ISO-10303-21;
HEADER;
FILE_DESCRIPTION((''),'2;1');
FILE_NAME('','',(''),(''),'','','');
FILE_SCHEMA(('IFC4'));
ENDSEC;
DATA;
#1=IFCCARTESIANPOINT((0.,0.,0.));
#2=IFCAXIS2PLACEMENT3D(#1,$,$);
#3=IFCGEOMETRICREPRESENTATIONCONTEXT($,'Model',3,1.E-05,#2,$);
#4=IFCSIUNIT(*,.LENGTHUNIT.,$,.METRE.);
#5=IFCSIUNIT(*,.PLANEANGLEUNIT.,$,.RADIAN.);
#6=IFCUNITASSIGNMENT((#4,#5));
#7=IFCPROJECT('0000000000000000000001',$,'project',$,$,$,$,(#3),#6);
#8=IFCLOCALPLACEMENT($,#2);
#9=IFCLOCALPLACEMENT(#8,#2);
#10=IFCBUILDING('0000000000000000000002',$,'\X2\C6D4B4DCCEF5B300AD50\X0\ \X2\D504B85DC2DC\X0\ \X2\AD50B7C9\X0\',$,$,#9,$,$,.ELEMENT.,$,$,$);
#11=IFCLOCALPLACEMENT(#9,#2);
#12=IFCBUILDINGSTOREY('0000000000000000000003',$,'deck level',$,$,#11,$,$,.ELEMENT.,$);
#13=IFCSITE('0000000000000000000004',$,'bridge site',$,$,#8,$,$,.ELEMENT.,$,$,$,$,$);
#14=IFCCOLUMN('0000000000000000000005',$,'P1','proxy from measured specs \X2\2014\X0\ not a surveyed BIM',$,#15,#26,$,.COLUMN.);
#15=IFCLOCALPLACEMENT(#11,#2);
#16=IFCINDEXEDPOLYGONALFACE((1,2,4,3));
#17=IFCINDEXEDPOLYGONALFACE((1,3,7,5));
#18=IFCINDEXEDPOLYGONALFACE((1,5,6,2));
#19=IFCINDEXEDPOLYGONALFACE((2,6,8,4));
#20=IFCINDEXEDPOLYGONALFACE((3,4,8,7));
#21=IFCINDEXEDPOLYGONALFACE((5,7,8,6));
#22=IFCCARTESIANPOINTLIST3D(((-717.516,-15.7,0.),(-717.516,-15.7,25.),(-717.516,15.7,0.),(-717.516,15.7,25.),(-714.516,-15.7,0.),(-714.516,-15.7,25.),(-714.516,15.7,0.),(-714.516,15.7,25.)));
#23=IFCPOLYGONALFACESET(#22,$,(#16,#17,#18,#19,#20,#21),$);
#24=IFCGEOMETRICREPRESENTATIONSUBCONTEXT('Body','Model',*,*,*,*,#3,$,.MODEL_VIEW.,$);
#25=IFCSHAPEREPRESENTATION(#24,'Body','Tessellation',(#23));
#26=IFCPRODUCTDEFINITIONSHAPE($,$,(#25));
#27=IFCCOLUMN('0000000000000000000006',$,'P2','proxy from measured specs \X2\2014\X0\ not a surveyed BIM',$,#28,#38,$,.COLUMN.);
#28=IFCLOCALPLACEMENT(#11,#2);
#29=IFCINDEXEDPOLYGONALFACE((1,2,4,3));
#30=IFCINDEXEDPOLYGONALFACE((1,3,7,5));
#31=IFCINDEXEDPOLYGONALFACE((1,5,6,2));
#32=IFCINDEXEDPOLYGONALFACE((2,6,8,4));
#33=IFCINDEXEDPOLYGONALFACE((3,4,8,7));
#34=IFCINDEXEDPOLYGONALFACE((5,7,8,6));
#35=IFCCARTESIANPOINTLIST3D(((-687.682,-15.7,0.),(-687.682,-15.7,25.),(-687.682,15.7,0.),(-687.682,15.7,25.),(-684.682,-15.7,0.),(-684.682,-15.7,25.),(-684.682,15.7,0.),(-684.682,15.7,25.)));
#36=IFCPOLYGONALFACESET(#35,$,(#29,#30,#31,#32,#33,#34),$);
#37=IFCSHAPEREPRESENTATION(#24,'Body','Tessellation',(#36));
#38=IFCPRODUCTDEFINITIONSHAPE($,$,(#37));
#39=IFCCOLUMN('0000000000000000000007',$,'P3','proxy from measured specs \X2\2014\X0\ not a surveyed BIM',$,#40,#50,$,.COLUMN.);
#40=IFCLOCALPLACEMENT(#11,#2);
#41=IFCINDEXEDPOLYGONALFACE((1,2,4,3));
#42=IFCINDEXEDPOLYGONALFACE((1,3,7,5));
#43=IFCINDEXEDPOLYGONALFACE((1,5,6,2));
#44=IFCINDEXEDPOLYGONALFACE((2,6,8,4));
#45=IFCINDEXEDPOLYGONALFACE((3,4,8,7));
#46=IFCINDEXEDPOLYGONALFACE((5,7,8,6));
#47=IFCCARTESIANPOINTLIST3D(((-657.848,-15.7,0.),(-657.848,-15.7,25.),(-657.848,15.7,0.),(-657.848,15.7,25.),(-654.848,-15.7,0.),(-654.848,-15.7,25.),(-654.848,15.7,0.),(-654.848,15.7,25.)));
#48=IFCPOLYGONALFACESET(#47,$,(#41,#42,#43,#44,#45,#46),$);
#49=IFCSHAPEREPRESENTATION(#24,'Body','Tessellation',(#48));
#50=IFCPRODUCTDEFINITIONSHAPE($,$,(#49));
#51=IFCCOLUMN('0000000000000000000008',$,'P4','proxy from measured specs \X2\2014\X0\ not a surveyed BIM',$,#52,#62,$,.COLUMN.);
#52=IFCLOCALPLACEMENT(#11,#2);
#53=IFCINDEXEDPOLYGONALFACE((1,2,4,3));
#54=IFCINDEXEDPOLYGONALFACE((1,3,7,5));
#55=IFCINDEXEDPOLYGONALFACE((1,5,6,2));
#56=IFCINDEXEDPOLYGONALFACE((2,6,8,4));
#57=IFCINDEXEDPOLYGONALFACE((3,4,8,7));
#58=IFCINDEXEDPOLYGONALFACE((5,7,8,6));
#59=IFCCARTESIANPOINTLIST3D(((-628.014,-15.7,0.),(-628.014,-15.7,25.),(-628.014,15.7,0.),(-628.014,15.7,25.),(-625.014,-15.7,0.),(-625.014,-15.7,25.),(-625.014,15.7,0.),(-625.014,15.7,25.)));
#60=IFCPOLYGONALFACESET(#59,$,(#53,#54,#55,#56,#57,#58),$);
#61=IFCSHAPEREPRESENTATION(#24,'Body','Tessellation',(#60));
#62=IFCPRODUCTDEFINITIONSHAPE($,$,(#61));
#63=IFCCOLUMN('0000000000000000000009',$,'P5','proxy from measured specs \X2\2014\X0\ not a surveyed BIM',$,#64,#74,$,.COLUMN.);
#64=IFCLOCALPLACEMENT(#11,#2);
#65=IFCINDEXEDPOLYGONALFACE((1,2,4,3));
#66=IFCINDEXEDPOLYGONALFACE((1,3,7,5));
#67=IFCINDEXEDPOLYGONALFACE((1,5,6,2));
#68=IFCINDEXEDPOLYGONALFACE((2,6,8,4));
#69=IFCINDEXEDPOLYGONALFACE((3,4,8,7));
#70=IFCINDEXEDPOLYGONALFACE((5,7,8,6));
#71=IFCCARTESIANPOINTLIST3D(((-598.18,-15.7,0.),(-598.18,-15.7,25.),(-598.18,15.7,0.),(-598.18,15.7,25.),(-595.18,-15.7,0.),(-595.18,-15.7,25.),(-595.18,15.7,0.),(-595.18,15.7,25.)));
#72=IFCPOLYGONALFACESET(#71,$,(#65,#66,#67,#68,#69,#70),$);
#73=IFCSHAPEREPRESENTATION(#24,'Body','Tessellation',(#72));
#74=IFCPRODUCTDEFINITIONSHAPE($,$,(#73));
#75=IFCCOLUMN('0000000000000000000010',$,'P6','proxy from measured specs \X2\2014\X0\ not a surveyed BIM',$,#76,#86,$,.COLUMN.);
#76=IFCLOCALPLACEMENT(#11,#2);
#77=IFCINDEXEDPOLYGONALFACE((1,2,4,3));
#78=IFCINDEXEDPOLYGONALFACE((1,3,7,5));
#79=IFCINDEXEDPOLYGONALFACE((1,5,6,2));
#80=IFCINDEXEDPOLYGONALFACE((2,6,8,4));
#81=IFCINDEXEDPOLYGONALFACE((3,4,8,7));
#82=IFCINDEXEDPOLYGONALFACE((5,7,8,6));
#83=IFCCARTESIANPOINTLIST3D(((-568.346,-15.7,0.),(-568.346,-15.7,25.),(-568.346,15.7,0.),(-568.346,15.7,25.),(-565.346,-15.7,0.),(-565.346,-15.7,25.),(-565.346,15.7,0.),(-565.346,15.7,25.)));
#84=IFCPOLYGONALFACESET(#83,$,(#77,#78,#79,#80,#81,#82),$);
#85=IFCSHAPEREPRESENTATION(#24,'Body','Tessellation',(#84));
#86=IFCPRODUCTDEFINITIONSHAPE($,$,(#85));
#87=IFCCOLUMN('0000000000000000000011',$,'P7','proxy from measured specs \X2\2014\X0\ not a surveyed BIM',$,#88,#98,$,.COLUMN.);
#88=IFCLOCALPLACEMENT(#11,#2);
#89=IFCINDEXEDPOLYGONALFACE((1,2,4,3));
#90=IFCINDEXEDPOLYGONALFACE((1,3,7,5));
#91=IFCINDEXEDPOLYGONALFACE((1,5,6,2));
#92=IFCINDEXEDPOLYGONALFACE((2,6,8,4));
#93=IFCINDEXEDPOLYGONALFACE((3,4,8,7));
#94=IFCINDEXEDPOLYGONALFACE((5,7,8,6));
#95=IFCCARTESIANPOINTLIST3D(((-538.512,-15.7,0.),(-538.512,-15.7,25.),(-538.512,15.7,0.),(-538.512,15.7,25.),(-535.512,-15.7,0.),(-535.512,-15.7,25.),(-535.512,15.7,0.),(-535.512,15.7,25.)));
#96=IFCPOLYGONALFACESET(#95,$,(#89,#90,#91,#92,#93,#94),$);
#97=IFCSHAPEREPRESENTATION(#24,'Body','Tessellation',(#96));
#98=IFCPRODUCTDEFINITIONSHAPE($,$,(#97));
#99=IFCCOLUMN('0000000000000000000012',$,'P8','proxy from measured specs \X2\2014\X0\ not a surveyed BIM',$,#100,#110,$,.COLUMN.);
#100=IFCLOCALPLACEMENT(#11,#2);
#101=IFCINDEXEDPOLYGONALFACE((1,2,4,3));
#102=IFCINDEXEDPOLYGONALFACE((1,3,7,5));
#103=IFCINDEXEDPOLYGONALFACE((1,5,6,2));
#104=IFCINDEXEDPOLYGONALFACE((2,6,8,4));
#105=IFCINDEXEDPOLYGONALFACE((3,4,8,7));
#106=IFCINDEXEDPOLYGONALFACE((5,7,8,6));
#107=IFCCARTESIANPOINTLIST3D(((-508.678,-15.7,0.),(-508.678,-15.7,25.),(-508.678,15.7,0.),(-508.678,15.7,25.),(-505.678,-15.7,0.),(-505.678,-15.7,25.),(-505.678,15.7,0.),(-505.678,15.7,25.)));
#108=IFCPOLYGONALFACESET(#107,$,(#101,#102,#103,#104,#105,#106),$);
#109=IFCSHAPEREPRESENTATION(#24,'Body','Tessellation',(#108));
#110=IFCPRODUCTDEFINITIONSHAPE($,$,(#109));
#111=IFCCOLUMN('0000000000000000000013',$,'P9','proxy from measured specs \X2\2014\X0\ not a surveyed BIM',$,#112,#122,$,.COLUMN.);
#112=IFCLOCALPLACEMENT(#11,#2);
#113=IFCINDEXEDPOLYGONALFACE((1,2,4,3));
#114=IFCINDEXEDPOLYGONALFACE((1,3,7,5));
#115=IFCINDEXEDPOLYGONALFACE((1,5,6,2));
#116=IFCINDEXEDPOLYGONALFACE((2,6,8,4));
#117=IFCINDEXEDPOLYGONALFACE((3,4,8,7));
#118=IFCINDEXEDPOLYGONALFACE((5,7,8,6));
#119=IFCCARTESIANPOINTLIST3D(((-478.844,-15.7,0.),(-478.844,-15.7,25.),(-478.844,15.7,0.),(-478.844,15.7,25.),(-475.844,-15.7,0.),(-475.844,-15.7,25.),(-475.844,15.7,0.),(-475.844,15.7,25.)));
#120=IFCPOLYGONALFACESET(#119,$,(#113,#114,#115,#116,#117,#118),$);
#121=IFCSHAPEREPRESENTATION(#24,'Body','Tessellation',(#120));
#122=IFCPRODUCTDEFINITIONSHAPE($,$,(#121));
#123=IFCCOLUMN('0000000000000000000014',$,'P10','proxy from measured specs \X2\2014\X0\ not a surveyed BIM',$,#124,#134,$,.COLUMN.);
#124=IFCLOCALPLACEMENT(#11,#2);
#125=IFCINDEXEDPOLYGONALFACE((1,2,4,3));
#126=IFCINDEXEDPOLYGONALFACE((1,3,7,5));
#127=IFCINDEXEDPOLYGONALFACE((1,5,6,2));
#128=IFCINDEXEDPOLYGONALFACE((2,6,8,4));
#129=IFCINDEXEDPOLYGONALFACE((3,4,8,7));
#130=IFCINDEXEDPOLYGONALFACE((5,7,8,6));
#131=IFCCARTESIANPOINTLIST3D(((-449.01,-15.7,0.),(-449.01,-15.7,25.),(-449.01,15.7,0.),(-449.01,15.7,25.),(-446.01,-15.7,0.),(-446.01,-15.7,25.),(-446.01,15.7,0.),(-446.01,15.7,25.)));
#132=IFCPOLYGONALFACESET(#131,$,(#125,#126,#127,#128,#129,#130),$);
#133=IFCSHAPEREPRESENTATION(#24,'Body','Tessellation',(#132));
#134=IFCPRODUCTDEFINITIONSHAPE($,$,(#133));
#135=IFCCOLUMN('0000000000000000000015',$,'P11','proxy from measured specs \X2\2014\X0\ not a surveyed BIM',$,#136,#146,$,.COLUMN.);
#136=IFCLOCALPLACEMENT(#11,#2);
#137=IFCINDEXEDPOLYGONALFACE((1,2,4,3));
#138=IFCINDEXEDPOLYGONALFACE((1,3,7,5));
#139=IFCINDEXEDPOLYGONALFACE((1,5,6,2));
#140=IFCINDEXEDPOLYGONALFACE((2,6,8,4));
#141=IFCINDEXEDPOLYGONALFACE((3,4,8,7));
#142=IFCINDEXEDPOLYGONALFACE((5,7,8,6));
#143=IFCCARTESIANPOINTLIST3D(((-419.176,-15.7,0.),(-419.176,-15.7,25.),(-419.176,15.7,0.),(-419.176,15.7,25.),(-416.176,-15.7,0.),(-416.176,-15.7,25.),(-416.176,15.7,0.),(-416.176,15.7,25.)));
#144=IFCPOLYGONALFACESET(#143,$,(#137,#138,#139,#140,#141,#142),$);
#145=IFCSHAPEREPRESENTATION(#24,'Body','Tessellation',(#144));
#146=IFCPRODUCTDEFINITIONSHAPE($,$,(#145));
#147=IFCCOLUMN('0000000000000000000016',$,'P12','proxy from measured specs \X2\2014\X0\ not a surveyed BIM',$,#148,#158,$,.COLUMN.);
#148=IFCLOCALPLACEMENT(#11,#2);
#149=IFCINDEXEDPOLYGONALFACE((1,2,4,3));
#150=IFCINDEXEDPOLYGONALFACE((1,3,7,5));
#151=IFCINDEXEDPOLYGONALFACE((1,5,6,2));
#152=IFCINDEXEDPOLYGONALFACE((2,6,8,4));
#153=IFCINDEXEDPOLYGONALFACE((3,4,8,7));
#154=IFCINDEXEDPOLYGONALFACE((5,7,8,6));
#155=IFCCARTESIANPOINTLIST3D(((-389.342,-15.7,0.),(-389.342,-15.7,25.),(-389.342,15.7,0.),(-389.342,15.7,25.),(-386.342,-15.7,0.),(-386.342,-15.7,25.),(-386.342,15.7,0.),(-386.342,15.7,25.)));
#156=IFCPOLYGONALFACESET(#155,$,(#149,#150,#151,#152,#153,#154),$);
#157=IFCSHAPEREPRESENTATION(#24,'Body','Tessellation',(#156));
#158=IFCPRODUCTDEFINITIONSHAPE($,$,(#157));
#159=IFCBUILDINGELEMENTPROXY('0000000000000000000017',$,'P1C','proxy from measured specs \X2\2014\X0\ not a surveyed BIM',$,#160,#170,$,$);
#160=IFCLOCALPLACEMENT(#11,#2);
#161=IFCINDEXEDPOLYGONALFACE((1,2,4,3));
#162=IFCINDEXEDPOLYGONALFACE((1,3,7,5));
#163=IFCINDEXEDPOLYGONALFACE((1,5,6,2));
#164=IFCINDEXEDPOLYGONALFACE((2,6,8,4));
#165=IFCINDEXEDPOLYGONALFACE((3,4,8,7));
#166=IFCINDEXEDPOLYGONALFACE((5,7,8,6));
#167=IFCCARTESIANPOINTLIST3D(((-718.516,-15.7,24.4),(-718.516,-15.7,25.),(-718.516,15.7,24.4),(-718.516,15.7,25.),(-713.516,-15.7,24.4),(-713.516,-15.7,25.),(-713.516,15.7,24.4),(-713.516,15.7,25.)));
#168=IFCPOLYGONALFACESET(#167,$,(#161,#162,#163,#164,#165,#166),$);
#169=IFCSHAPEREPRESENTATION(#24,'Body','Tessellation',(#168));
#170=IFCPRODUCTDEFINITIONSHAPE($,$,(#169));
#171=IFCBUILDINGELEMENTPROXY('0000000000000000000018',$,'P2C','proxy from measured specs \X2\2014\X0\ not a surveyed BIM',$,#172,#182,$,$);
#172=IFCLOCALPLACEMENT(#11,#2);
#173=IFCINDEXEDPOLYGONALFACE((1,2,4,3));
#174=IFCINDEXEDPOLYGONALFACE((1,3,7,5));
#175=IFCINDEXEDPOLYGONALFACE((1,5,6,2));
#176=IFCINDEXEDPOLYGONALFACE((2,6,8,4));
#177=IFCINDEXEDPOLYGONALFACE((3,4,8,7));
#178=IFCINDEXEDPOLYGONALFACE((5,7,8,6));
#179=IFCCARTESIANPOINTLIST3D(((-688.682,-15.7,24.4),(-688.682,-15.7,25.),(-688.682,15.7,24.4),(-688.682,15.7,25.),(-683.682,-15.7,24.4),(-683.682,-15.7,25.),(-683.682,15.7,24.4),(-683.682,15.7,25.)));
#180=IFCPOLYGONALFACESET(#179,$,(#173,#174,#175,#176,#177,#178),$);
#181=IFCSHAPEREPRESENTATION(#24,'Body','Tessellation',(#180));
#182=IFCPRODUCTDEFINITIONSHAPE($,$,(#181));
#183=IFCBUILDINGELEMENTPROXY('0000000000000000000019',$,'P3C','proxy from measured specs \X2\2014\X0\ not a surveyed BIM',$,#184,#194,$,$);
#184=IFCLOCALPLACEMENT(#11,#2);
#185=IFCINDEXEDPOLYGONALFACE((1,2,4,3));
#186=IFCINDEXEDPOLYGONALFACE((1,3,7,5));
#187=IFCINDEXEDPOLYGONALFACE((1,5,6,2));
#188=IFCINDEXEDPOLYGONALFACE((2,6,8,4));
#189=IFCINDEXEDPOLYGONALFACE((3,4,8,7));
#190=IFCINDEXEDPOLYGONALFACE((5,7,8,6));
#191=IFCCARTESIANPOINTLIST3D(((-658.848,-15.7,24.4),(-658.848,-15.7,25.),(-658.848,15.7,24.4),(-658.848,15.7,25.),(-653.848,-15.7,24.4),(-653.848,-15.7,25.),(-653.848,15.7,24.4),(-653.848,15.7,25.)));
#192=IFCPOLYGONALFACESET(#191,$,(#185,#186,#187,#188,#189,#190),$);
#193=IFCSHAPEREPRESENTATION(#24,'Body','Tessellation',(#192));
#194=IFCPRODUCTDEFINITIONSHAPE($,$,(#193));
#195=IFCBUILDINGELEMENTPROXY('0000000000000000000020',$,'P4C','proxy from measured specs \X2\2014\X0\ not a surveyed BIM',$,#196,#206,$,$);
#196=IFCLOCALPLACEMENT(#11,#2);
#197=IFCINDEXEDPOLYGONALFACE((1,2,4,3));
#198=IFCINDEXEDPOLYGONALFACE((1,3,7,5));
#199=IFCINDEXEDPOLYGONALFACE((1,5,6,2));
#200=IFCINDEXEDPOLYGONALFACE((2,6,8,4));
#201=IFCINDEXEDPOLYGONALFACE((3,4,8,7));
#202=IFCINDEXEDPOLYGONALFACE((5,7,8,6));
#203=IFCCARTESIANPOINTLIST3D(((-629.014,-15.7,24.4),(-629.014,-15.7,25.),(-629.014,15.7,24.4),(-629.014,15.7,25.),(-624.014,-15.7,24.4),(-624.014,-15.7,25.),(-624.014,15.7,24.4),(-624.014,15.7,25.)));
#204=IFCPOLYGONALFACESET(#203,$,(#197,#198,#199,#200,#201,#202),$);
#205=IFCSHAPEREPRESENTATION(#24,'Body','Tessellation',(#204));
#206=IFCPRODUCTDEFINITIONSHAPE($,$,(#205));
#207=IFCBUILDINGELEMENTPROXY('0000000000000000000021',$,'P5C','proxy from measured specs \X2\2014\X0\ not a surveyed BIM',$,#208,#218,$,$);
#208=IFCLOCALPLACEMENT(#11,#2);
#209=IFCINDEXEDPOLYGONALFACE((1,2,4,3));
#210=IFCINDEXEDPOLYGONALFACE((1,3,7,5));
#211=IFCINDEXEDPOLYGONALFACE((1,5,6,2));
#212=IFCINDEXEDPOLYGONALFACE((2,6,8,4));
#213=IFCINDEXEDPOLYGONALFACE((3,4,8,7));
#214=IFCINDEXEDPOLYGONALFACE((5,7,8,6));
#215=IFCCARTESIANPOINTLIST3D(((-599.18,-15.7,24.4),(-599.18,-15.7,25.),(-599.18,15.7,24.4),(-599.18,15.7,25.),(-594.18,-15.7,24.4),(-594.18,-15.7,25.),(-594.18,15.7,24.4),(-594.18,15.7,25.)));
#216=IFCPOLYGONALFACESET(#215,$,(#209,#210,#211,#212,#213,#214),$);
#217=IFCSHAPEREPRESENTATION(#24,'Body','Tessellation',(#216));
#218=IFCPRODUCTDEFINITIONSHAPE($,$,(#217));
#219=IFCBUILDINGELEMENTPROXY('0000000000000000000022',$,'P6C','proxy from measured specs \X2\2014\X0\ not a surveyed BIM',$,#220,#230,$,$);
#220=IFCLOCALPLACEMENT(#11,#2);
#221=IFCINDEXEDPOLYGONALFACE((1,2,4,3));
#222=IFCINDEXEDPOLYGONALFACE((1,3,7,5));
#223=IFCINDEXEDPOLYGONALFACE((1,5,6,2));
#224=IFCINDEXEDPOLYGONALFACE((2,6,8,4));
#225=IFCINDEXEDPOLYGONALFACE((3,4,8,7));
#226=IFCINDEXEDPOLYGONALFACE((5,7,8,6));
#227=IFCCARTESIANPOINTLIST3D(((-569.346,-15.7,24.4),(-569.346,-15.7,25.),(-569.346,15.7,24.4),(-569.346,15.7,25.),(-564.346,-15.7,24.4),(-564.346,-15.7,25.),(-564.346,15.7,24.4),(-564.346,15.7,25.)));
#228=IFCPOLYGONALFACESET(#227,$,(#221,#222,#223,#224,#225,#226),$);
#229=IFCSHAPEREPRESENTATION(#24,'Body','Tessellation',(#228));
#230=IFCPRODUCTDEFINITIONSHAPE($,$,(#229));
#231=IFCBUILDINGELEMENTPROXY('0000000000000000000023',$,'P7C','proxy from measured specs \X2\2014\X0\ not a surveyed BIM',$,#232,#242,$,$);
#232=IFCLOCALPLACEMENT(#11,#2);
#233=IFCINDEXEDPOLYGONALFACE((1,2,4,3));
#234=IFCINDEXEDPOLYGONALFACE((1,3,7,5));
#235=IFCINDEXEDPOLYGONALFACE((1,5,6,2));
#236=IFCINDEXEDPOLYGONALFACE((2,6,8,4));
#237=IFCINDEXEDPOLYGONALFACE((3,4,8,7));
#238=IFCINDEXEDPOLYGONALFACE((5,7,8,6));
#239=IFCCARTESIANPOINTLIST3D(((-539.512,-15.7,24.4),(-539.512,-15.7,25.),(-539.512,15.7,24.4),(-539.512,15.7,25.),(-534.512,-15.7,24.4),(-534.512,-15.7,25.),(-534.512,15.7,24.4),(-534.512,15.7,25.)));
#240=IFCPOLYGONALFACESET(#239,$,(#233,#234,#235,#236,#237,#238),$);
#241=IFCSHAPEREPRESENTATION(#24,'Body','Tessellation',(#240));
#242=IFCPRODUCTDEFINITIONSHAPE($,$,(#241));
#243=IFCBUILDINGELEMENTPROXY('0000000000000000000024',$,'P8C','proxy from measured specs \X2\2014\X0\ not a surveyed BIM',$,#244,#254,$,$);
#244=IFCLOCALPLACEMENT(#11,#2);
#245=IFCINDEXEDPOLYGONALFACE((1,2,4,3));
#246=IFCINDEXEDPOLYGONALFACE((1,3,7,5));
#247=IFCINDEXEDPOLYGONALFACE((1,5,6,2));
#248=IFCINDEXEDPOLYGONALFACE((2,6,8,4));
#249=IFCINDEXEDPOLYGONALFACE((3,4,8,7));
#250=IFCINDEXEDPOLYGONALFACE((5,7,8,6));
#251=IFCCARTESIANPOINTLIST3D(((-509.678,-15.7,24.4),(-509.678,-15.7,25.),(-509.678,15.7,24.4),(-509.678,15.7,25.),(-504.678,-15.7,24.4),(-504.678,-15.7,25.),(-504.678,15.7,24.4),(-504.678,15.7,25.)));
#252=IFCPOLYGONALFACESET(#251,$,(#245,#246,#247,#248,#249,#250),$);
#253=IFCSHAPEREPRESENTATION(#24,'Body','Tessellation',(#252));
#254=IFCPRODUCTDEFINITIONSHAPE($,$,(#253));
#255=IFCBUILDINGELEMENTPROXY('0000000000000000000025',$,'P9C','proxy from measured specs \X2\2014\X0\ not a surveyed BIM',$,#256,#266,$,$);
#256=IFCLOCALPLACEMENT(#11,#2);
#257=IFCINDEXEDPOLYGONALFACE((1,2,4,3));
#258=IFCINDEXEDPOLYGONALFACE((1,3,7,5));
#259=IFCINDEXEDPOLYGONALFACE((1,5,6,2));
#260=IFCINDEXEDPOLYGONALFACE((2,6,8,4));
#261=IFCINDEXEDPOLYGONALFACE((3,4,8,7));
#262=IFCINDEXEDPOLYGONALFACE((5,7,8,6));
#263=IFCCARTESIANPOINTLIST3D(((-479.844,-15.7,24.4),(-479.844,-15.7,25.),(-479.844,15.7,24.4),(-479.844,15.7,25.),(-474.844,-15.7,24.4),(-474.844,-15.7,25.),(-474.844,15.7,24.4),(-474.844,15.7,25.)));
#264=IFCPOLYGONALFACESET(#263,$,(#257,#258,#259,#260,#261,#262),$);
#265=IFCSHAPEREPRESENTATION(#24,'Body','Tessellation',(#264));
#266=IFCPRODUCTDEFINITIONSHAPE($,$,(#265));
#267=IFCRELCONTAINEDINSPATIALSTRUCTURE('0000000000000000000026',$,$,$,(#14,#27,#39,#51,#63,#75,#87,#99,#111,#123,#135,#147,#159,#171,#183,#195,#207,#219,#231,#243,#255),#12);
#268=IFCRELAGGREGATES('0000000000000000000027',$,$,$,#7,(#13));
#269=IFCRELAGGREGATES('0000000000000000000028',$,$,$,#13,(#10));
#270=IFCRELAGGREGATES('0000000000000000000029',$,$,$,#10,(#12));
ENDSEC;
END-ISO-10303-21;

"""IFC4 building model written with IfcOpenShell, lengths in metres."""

from ifc_helpers import new_model, si_unit, frame, origin, origin_2d, place, context, subcontext, project, spatial, rectangle, extrude, element, save


model = new_model("IFC4")

# Units and contexts
model_context = context("Model", 3, precision=1e-05, world=origin())
body_context = subcontext(model_context, "Body", "Model", "MODEL_VIEW")
ifc_project = project(units=[si_unit("LENGTHUNIT", "METRE"), si_unit("PLANEANGLEUNIT", "RADIAN")], contexts=[model_context])

# Site, building, storey
site_placement = place(None, origin())
site = spatial("IfcSite", under=ifc_project, at=site_placement, Name="bridge site", CompositionType="ELEMENT")
building_placement = place(site_placement, origin())
building = spatial("IfcBuilding", under=site, at=building_placement, Name="월드컵대교 프록시 교량", CompositionType="ELEMENT")
storey_placement = place(building_placement, origin())
storey = spatial("IfcBuildingStorey", under=building, at=storey_placement, Name="deck level", CompositionType="ELEMENT")

# Columns
for number, where, name in (
    (1, (-716.016, 0.0, 0.0), "P1"),
    (2, (-686.182, 0.0, 0.0), "P2"),
    (3, (-656.348, 0.0, 0.0), "P3"),
    (4, (-626.514, 0.0, 0.0), "P4"),
    (5, (-596.68, 0.0, 0.0), "P5"),
    (6, (-566.846, 0.0, 0.0), "P6"),
    (7, (-537.012, 0.0, 0.0), "P7"),
    (8, (-507.178, 0.0, 0.0), "P8"),
    (9, (-477.344, 0.0, 0.0), "P9"),
    (10, (-447.51, 0.0, 0.0), "P10"),
    (11, (-417.676, 0.0, 0.0), "P11"),
    (12, (-387.842, 0.0, 0.0), "P12"),
):
    element("IfcColumn", number, at=place(storey_placement, frame(where)), inside=storey, Name=name, Description="proxy from measured specs — not a surveyed BIM", PredefinedType="COLUMN", context=body_context, shape_type="SweptSolid", body=[
        extrude(rectangle(XDim=3.0, YDim=31.4, at=origin_2d()), origin(), (0.0, 0.0, 1.0), 25.0),
    ])

# Building element proxies
for number, where, name in (
    (13, (-716.016, 0.0, 24.4), "P1C"),
    (14, (-686.182, 0.0, 24.4), "P2C"),
    (15, (-656.348, 0.0, 24.4), "P3C"),
    (16, (-626.514, 0.0, 24.4), "P4C"),
    (17, (-596.68, 0.0, 24.4), "P5C"),
    (18, (-566.846, 0.0, 24.4), "P6C"),
    (19, (-537.012, 0.0, 24.4), "P7C"),
    (20, (-507.178, 0.0, 24.4), "P8C"),
    (21, (-477.344, 0.0, 24.4), "P9C"),
):
    element("IfcBuildingElementProxy", number, at=place(storey_placement, frame(where)), inside=storey, Name=name, Description="proxy from measured specs — not a surveyed BIM", context=body_context, shape_type="SweptSolid", body=[
        extrude(rectangle(XDim=5.0, YDim=31.4, at=origin_2d()), origin(), (0.0, 0.0, 1.0), 0.6),
    ])

save(model, "model.ifc")
